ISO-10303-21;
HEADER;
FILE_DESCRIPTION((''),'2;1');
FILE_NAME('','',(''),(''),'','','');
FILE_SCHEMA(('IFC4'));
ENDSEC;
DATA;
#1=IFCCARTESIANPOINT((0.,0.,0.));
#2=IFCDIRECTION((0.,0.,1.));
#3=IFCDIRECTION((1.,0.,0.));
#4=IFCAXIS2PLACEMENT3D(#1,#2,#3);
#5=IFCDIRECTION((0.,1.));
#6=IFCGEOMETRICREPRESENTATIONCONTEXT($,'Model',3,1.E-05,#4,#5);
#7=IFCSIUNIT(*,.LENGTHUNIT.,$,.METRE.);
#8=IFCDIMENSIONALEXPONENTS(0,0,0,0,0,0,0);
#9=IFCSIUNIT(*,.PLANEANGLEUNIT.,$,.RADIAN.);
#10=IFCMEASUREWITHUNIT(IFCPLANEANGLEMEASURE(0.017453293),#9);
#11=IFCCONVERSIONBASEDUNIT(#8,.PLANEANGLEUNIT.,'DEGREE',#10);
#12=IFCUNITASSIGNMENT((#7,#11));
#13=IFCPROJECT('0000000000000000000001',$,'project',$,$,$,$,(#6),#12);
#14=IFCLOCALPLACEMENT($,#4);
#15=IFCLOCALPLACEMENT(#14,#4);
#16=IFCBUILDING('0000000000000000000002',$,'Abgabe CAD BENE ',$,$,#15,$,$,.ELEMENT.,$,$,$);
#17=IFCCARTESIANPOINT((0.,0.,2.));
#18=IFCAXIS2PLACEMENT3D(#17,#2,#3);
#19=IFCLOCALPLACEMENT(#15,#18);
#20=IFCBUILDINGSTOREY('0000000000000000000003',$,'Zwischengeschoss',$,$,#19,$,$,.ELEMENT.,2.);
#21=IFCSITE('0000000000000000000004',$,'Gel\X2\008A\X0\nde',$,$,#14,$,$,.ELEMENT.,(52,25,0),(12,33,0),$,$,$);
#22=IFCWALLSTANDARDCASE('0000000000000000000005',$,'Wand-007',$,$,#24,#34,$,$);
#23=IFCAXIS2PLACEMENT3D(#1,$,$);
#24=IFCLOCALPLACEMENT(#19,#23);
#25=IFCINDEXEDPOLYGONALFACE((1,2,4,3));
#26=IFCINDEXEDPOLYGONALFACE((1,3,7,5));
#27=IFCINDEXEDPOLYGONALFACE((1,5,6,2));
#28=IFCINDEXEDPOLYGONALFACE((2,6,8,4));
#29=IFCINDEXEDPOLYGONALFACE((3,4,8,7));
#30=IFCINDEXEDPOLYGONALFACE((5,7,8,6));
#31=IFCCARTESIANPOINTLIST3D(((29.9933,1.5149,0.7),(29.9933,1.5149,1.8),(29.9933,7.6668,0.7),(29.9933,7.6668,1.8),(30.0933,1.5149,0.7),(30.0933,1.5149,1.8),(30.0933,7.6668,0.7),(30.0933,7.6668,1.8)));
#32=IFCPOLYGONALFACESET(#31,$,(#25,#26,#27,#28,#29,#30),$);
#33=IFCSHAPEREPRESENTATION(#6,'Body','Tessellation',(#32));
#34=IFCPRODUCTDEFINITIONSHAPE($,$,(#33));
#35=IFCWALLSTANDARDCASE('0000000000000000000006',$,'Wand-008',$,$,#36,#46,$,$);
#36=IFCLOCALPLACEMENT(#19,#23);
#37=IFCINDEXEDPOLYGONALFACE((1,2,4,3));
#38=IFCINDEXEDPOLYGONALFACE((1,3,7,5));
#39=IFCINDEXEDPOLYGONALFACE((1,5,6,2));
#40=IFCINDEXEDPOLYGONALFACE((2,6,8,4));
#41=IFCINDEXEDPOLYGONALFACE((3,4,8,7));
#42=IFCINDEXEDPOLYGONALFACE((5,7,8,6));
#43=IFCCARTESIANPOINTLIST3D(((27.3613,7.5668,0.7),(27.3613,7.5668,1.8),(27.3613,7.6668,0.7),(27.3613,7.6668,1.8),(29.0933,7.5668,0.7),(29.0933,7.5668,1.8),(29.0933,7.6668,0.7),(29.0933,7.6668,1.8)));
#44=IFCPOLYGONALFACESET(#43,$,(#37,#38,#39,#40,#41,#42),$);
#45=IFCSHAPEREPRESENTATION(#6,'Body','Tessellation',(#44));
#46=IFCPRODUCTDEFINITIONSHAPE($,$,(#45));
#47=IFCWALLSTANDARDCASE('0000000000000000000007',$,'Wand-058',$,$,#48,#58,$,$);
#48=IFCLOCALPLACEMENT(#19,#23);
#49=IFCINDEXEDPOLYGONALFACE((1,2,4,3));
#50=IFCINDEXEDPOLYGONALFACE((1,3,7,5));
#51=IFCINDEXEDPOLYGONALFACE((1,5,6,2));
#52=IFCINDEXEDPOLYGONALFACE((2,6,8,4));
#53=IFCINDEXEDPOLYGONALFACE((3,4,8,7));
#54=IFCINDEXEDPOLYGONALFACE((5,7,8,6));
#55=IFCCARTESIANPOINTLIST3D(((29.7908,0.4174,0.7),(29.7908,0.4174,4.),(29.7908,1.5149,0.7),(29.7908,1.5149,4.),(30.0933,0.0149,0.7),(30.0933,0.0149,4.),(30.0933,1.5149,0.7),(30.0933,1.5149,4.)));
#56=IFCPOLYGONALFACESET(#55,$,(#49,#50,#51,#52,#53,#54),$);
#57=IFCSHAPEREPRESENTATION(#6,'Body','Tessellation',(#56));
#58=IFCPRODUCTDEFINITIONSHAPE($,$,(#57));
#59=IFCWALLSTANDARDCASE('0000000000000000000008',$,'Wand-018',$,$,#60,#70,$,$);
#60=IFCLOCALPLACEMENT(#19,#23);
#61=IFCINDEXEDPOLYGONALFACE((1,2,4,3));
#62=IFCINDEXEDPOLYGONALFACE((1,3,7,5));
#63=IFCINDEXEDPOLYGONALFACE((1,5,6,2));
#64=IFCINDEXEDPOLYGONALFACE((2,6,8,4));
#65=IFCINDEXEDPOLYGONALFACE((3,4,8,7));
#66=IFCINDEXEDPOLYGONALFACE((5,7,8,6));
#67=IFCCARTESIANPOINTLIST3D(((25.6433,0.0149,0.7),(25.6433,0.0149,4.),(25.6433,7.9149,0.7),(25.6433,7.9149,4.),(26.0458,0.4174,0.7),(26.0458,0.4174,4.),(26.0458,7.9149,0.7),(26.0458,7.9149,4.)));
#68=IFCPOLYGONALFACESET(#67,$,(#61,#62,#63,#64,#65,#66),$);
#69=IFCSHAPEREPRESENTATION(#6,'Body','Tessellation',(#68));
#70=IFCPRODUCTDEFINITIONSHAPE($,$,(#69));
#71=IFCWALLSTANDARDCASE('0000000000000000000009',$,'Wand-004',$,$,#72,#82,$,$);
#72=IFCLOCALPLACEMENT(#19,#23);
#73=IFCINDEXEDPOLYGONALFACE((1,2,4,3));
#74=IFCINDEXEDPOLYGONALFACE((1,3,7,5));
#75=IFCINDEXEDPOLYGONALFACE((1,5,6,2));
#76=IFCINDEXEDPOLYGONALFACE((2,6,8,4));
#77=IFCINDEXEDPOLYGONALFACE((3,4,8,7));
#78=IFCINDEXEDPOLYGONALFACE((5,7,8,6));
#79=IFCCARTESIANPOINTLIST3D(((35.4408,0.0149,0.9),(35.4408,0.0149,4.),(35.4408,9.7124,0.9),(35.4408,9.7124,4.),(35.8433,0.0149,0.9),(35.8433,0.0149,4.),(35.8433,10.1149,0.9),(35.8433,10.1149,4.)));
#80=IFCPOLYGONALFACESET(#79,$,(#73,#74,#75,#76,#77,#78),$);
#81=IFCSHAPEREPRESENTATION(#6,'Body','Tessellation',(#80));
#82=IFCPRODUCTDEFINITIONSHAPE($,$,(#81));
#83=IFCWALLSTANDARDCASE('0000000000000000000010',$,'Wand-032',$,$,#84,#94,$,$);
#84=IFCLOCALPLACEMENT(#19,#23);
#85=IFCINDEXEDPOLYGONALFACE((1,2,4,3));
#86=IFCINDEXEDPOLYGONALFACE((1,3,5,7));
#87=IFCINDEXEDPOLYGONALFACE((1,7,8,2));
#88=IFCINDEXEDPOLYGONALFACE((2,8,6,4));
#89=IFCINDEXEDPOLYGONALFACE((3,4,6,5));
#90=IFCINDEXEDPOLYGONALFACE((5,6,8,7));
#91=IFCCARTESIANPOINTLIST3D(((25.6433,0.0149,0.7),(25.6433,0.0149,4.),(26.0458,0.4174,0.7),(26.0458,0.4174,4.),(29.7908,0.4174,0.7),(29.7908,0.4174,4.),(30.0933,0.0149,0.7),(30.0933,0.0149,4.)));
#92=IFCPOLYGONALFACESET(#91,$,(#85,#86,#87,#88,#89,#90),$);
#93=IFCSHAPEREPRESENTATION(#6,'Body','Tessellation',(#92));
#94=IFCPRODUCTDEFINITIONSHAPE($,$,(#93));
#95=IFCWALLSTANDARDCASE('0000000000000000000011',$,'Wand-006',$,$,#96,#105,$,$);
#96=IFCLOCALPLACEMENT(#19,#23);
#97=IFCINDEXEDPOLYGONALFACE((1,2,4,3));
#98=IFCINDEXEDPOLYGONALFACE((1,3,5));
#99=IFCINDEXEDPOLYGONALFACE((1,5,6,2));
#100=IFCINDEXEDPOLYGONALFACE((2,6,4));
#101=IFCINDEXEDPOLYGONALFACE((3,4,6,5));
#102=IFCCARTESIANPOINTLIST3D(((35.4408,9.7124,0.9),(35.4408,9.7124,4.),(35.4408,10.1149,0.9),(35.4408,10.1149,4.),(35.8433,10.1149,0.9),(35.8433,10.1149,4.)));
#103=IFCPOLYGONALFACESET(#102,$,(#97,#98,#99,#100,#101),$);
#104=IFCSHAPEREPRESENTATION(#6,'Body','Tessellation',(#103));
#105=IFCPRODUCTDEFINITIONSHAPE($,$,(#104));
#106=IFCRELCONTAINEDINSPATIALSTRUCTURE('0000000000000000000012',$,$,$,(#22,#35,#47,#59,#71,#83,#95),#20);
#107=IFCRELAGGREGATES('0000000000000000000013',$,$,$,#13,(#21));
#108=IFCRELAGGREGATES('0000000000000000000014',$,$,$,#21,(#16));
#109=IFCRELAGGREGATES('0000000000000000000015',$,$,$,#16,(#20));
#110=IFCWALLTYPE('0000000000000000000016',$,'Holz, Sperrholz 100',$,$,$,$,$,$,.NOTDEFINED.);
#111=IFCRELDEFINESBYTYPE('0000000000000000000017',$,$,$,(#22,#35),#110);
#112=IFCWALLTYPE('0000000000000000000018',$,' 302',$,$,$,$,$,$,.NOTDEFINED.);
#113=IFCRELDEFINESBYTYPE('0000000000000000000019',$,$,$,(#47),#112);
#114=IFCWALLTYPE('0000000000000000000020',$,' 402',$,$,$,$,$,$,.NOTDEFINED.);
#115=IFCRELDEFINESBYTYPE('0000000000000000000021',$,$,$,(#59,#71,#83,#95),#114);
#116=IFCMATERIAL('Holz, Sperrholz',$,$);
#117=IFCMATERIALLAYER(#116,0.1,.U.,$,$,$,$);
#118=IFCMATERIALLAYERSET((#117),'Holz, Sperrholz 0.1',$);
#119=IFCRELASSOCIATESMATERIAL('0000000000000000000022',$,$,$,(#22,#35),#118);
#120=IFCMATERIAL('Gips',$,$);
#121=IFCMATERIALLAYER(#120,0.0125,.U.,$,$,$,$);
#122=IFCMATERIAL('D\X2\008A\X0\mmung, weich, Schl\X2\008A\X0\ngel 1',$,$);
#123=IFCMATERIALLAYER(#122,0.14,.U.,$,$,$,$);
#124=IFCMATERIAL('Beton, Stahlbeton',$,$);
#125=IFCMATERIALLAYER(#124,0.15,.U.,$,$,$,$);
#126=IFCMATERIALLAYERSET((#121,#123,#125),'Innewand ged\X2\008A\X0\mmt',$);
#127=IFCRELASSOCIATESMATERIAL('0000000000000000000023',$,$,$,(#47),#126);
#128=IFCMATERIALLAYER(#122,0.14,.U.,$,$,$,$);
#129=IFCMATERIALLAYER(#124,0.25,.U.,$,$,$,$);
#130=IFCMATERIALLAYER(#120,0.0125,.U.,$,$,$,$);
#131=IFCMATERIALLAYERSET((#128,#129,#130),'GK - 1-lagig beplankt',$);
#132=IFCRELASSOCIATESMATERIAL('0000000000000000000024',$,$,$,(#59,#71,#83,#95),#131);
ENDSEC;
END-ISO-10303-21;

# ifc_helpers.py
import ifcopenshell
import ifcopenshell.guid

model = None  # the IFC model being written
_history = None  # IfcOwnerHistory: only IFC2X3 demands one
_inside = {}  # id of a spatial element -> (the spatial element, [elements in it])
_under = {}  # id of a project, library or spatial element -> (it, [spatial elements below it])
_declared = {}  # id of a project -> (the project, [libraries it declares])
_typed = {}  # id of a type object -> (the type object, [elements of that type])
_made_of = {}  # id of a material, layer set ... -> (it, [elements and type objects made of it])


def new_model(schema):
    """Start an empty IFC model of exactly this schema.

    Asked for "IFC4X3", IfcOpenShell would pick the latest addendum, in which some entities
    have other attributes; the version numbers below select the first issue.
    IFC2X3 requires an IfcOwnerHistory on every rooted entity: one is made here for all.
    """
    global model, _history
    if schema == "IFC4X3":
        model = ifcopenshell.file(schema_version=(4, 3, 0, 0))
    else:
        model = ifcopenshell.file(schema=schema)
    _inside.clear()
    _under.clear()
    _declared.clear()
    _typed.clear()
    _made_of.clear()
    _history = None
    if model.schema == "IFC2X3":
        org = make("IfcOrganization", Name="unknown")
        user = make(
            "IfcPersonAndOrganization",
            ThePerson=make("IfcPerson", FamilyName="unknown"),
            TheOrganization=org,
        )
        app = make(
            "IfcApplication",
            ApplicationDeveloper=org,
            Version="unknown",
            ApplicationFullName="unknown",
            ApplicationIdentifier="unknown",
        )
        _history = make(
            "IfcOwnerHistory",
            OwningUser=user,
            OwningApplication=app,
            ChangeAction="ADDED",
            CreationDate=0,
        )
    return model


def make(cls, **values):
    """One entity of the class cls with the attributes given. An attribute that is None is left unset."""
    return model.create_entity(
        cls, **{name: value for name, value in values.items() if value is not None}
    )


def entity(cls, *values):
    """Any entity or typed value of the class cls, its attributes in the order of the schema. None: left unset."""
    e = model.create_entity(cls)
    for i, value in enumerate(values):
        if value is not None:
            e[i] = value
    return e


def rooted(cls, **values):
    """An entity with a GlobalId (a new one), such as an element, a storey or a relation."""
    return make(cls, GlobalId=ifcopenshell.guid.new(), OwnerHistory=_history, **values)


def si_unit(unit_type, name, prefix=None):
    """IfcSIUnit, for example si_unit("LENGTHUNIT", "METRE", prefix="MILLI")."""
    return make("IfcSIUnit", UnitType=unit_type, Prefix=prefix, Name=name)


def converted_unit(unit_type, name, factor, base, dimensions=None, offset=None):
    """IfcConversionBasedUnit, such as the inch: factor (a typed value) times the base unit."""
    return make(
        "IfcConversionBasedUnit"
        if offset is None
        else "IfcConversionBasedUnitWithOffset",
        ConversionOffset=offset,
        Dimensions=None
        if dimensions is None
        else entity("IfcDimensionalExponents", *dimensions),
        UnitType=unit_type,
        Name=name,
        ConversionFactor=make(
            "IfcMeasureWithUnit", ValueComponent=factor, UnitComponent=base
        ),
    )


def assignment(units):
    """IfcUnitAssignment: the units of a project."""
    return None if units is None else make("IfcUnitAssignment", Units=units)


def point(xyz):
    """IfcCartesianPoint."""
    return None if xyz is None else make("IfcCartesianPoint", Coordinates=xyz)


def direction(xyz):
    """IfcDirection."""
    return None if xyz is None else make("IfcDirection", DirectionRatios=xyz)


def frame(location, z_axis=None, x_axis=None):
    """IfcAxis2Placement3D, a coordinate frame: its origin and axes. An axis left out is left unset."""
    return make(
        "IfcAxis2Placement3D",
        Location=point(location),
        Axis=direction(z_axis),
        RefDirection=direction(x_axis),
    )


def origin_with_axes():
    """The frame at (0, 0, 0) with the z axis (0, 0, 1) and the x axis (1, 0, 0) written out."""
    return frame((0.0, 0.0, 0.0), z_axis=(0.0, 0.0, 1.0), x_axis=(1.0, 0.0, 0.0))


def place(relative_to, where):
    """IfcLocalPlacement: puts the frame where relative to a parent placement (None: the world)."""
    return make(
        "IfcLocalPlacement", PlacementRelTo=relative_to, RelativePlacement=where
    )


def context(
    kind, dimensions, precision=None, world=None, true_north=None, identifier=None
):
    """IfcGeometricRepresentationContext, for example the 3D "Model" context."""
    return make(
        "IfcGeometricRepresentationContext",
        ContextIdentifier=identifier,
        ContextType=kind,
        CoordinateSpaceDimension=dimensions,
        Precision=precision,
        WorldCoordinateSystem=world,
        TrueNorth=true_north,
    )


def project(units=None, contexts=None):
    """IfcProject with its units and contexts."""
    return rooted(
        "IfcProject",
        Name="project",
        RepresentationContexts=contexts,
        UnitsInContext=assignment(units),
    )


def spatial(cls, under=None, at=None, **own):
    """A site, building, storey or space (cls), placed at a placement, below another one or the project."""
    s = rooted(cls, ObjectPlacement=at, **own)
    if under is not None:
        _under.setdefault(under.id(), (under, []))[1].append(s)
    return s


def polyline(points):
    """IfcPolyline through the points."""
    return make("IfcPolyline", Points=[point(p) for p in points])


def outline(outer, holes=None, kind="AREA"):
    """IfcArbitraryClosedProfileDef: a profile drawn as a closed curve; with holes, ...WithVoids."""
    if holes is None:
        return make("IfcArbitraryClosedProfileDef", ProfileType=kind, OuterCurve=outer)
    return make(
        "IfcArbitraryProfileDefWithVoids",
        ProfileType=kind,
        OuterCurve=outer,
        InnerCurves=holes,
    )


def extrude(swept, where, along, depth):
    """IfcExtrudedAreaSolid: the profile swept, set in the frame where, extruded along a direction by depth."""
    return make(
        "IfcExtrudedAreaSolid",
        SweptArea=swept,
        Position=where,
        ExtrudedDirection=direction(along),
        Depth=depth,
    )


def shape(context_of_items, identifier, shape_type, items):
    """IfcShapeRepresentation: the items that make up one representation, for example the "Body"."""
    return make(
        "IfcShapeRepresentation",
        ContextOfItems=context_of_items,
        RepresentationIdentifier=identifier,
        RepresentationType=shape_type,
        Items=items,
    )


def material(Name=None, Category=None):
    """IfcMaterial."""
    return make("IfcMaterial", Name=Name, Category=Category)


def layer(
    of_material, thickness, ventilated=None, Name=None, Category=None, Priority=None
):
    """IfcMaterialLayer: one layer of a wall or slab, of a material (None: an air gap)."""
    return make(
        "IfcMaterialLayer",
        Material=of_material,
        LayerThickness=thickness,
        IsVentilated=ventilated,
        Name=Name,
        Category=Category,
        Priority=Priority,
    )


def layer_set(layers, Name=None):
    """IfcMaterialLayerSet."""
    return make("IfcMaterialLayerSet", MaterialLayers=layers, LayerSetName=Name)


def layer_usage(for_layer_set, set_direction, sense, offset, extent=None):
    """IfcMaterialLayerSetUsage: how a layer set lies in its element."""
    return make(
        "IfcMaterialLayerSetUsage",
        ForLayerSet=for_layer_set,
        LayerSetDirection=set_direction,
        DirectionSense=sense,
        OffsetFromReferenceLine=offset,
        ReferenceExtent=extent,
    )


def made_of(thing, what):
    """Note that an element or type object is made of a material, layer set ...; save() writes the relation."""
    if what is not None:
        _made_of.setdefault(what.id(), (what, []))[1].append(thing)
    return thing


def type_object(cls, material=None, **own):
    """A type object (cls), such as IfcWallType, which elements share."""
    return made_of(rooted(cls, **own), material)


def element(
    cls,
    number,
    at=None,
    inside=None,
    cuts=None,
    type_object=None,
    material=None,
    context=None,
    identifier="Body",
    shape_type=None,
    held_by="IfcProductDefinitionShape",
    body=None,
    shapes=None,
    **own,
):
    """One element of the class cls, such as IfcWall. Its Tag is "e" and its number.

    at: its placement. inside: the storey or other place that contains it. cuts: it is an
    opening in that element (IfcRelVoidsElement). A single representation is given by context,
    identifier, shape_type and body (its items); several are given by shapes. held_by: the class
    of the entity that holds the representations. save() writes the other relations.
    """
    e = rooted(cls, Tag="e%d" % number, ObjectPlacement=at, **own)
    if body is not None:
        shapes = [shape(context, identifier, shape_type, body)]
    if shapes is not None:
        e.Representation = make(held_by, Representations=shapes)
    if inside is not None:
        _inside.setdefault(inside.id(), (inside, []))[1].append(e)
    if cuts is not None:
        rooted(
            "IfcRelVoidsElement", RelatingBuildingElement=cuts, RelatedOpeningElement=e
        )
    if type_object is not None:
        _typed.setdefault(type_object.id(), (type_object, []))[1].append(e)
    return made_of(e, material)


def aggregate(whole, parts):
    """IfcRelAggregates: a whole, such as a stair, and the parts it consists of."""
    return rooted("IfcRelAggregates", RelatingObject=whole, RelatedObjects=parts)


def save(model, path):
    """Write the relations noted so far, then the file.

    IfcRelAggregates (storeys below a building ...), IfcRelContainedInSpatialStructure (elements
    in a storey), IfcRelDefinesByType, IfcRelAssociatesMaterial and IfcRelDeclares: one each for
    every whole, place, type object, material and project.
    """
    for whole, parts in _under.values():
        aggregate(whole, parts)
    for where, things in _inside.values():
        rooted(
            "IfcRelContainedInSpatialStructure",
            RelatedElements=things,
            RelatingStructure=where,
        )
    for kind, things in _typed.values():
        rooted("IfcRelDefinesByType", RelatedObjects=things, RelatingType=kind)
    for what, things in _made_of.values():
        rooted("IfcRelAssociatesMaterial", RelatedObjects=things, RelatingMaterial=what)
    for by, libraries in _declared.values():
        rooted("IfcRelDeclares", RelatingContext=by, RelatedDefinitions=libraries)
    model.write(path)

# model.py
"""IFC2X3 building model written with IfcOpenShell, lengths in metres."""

from ifc_helpers import new_model, entity, si_unit, converted_unit, direction, frame, origin_with_axes, place, context, project, spatial, polyline, outline, extrude, material, layer, layer_set, layer_usage, type_object, element, save


model = new_model("IFC2X3")

# Units and contexts
model_context = context("Model", 3, precision=1e-05, world=origin_with_axes(), true_north=direction((0.0, 1.0)))
ifc_project = project(units=[si_unit("LENGTHUNIT", "METRE"), converted_unit("PLANEANGLEUNIT", "DEGREE", entity("IfcPlaneAngleMeasure", 0.017453293), si_unit("PLANEANGLEUNIT", "RADIAN"), dimensions=[0, 0, 0, 0, 0, 0, 0])], contexts=[model_context])

# Site, building, storey
site_placement = place(None, origin_with_axes())
site = spatial("IfcSite", under=ifc_project, at=site_placement, Name="Gel\u008ande", CompositionType="ELEMENT", RefLatitude=(52, 25, 0), RefLongitude=(12, 33, 0))
building_placement = place(site_placement, origin_with_axes())
building = spatial("IfcBuilding", under=site, at=building_placement, Name="Abgabe CAD BENE ", CompositionType="ELEMENT")
storey_placement = place(building_placement, frame((0.0, 0.0, 2.0), z_axis=(0.0, 0.0, 1.0), x_axis=(1.0, 0.0, 0.0)))
storey = spatial("IfcBuildingStorey", under=building, at=storey_placement, Name="Zwischengeschoss", CompositionType="ELEMENT", Elevation=2.0)

# Shared definitions
ifc_material_1 = material(Name="Beton, Stahlbeton")

# Walls
ifc_material_2 = material(Name="Holz, Sperrholz")
ifc_layer_1 = layer(ifc_material_2, 0.1, ventilated="UNKNOWN")
ifc_layer_set_1 = layer_set([ifc_layer_1], Name="Holz, Sperrholz 0.1")
ifc_layer_usage_1 = layer_usage(ifc_layer_set_1, "AXIS2", "NEGATIVE", 0.0)
wall_type_1 = type_object("IfcWallType", Name="Holz, Sperrholz 100", PredefinedType="NOTDEFINED")
wall_1_placement = place(storey_placement, frame((30.0933, 7.6668, 0.7), z_axis=(0.0, 0.0, 1.0), x_axis=(0.0, -1.0, 0.0)))
element("IfcWallStandardCase", 1, at=wall_1_placement, inside=storey, type_object=wall_type_1, material=ifc_layer_usage_1, Name="Wand-007", context=model_context, shape_type="SweptSolid", body=[
    extrude(outline(polyline([(0.0, -0.1), (6.152, -0.1), (6.152, 0.0), (0.0, 0.0), (0.0, -0.1)])), origin_with_axes(), (0.0, 0.0, 1.0), 1.1),
])
ifc_layer_usage_2 = layer_usage(ifc_layer_set_1, "AXIS2", "NEGATIVE", 0.0)
wall_2_placement = place(storey_placement, frame((27.3613, 7.6668, 0.7), z_axis=(0.0, 0.0, 1.0), x_axis=(1.0, 0.0, 0.0)))
element("IfcWallStandardCase", 2, at=wall_2_placement, inside=storey, type_object=wall_type_1, material=ifc_layer_usage_2, Name="Wand-008", context=model_context, shape_type="SweptSolid", body=[
    extrude(outline(polyline([(0.0, -0.1), (1.7319, -0.1), (1.7319, 0.0), (0.0, 0.0), (0.0, -0.1)])), origin_with_axes(), (0.0, 0.0, 1.0), 1.1),
])
ifc_material_3 = material(Name="Gips")
ifc_layer_2 = layer(ifc_material_3, 0.0125, ventilated="UNKNOWN")
ifc_material_4 = material(Name="D\u008ammung, weich, Schl\u008angel 1")
ifc_layer_3 = layer(ifc_material_4, 0.14, ventilated="UNKNOWN")
ifc_layer_4 = layer(ifc_material_1, 0.15, ventilated="UNKNOWN")
ifc_layer_set_2 = layer_set([ifc_layer_2, ifc_layer_3, ifc_layer_4], Name="Innewand ged\u008ammt")
ifc_layer_usage_3 = layer_usage(ifc_layer_set_2, "AXIS2", "NEGATIVE", 0.0)
wall_type_2 = type_object("IfcWallType", Name=" 302", PredefinedType="NOTDEFINED")
wall_3_placement = place(storey_placement, frame((30.0933, 1.5149, 0.7), z_axis=(0.0, 0.0, 1.0), x_axis=(0.0, -1.0, 0.0)))
element("IfcWallStandardCase", 3, at=wall_3_placement, inside=storey, type_object=wall_type_2, material=ifc_layer_usage_3, Name="Wand-058", context=model_context, shape_type="SweptSolid", body=[
    extrude(outline(polyline([(0.0, -0.3025), (1.0975, -0.3025), (1.5, 0.0), (0.0, 0.0), (0.0, -0.3025)])), origin_with_axes(), (0.0, 0.0, 1.0), 3.3),
])
ifc_layer_5 = layer(ifc_material_4, 0.14, ventilated="UNKNOWN")
ifc_layer_6 = layer(ifc_material_1, 0.25, ventilated="UNKNOWN")
ifc_layer_7 = layer(ifc_material_3, 0.0125, ventilated="UNKNOWN")
ifc_layer_set_3 = layer_set([ifc_layer_5, ifc_layer_6, ifc_layer_7], Name="GK - 1-lagig beplankt")
ifc_layer_usage_4 = layer_usage(ifc_layer_set_3, "AXIS2", "NEGATIVE", 0.0)
wall_type_3 = type_object("IfcWallType", Name=" 402", PredefinedType="NOTDEFINED")
wall_4_placement = place(storey_placement, frame((25.6433, 0.0149, 0.7), z_axis=(0.0, 0.0, 1.0), x_axis=(0.0, 1.0, 0.0)))
element("IfcWallStandardCase", 4, at=wall_4_placement, inside=storey, type_object=wall_type_3, material=ifc_layer_usage_4, Name="Wand-018", context=model_context, shape_type="SweptSolid", body=[
    extrude(outline(polyline([(0.4025, -0.4025), (7.9, -0.4025), (7.9, 0.0), (0.0, 0.0), (0.4025, -0.4025)])), origin_with_axes(), (0.0, 0.0, 1.0), 3.3),
])
ifc_layer_usage_5 = layer_usage(ifc_layer_set_3, "AXIS2", "NEGATIVE", 0.0)
wall_5_placement = place(storey_placement, frame((35.8433, 10.1149, 0.9), z_axis=(0.0, 0.0, 1.0), x_axis=(0.0, -1.0, 0.0)))
element("IfcWallStandardCase", 5, at=wall_5_placement, inside=storey, type_object=wall_type_3, material=ifc_layer_usage_5, Name="Wand-004", context=model_context, shape_type="SweptSolid", body=[
    extrude(outline(polyline([(0.4025, -0.4025), (10.1, -0.4025), (10.1, 0.0), (0.0, 0.0), (0.4025, -0.4025)])), origin_with_axes(), (0.0, 0.0, 1.0), 3.1),
])
ifc_layer_usage_6 = layer_usage(ifc_layer_set_3, "AXIS2", "NEGATIVE", 0.0)
wall_6_placement = place(storey_placement, frame((30.0933, 0.0149, 0.7), z_axis=(0.0, 0.0, 1.0), x_axis=(-1.0, 0.0, 0.0)))
element("IfcWallStandardCase", 6, at=wall_6_placement, inside=storey, type_object=wall_type_3, material=ifc_layer_usage_6, Name="Wand-032", context=model_context, shape_type="SweptSolid", body=[
    extrude(outline(polyline([(0.3025, -0.4025), (4.0475, -0.4025), (4.45, 0.0), (0.0, 0.0), (0.3025, -0.4025)])), origin_with_axes(), (0.0, 0.0, 1.0), 3.3),
])
ifc_layer_usage_7 = layer_usage(ifc_layer_set_3, "AXIS2", "NEGATIVE", 0.0)
wall_7_placement = place(storey_placement, frame((35.4408, 10.1149, 0.9), z_axis=(0.0, 0.0, 1.0), x_axis=(1.0, 0.0, 0.0)))
element("IfcWallStandardCase", 7, at=wall_7_placement, inside=storey, type_object=wall_type_3, material=ifc_layer_usage_7, Name="Wand-006", context=model_context, shape_type="SweptSolid", body=[
    extrude(outline(polyline([(0.0, -0.4025), (0.4025, 0.0), (0.0, 0.0), (0.0, -0.4025)])), origin_with_axes(), (0.0, 0.0, 1.0), 3.1),
])

save(model, "model.ifc")
